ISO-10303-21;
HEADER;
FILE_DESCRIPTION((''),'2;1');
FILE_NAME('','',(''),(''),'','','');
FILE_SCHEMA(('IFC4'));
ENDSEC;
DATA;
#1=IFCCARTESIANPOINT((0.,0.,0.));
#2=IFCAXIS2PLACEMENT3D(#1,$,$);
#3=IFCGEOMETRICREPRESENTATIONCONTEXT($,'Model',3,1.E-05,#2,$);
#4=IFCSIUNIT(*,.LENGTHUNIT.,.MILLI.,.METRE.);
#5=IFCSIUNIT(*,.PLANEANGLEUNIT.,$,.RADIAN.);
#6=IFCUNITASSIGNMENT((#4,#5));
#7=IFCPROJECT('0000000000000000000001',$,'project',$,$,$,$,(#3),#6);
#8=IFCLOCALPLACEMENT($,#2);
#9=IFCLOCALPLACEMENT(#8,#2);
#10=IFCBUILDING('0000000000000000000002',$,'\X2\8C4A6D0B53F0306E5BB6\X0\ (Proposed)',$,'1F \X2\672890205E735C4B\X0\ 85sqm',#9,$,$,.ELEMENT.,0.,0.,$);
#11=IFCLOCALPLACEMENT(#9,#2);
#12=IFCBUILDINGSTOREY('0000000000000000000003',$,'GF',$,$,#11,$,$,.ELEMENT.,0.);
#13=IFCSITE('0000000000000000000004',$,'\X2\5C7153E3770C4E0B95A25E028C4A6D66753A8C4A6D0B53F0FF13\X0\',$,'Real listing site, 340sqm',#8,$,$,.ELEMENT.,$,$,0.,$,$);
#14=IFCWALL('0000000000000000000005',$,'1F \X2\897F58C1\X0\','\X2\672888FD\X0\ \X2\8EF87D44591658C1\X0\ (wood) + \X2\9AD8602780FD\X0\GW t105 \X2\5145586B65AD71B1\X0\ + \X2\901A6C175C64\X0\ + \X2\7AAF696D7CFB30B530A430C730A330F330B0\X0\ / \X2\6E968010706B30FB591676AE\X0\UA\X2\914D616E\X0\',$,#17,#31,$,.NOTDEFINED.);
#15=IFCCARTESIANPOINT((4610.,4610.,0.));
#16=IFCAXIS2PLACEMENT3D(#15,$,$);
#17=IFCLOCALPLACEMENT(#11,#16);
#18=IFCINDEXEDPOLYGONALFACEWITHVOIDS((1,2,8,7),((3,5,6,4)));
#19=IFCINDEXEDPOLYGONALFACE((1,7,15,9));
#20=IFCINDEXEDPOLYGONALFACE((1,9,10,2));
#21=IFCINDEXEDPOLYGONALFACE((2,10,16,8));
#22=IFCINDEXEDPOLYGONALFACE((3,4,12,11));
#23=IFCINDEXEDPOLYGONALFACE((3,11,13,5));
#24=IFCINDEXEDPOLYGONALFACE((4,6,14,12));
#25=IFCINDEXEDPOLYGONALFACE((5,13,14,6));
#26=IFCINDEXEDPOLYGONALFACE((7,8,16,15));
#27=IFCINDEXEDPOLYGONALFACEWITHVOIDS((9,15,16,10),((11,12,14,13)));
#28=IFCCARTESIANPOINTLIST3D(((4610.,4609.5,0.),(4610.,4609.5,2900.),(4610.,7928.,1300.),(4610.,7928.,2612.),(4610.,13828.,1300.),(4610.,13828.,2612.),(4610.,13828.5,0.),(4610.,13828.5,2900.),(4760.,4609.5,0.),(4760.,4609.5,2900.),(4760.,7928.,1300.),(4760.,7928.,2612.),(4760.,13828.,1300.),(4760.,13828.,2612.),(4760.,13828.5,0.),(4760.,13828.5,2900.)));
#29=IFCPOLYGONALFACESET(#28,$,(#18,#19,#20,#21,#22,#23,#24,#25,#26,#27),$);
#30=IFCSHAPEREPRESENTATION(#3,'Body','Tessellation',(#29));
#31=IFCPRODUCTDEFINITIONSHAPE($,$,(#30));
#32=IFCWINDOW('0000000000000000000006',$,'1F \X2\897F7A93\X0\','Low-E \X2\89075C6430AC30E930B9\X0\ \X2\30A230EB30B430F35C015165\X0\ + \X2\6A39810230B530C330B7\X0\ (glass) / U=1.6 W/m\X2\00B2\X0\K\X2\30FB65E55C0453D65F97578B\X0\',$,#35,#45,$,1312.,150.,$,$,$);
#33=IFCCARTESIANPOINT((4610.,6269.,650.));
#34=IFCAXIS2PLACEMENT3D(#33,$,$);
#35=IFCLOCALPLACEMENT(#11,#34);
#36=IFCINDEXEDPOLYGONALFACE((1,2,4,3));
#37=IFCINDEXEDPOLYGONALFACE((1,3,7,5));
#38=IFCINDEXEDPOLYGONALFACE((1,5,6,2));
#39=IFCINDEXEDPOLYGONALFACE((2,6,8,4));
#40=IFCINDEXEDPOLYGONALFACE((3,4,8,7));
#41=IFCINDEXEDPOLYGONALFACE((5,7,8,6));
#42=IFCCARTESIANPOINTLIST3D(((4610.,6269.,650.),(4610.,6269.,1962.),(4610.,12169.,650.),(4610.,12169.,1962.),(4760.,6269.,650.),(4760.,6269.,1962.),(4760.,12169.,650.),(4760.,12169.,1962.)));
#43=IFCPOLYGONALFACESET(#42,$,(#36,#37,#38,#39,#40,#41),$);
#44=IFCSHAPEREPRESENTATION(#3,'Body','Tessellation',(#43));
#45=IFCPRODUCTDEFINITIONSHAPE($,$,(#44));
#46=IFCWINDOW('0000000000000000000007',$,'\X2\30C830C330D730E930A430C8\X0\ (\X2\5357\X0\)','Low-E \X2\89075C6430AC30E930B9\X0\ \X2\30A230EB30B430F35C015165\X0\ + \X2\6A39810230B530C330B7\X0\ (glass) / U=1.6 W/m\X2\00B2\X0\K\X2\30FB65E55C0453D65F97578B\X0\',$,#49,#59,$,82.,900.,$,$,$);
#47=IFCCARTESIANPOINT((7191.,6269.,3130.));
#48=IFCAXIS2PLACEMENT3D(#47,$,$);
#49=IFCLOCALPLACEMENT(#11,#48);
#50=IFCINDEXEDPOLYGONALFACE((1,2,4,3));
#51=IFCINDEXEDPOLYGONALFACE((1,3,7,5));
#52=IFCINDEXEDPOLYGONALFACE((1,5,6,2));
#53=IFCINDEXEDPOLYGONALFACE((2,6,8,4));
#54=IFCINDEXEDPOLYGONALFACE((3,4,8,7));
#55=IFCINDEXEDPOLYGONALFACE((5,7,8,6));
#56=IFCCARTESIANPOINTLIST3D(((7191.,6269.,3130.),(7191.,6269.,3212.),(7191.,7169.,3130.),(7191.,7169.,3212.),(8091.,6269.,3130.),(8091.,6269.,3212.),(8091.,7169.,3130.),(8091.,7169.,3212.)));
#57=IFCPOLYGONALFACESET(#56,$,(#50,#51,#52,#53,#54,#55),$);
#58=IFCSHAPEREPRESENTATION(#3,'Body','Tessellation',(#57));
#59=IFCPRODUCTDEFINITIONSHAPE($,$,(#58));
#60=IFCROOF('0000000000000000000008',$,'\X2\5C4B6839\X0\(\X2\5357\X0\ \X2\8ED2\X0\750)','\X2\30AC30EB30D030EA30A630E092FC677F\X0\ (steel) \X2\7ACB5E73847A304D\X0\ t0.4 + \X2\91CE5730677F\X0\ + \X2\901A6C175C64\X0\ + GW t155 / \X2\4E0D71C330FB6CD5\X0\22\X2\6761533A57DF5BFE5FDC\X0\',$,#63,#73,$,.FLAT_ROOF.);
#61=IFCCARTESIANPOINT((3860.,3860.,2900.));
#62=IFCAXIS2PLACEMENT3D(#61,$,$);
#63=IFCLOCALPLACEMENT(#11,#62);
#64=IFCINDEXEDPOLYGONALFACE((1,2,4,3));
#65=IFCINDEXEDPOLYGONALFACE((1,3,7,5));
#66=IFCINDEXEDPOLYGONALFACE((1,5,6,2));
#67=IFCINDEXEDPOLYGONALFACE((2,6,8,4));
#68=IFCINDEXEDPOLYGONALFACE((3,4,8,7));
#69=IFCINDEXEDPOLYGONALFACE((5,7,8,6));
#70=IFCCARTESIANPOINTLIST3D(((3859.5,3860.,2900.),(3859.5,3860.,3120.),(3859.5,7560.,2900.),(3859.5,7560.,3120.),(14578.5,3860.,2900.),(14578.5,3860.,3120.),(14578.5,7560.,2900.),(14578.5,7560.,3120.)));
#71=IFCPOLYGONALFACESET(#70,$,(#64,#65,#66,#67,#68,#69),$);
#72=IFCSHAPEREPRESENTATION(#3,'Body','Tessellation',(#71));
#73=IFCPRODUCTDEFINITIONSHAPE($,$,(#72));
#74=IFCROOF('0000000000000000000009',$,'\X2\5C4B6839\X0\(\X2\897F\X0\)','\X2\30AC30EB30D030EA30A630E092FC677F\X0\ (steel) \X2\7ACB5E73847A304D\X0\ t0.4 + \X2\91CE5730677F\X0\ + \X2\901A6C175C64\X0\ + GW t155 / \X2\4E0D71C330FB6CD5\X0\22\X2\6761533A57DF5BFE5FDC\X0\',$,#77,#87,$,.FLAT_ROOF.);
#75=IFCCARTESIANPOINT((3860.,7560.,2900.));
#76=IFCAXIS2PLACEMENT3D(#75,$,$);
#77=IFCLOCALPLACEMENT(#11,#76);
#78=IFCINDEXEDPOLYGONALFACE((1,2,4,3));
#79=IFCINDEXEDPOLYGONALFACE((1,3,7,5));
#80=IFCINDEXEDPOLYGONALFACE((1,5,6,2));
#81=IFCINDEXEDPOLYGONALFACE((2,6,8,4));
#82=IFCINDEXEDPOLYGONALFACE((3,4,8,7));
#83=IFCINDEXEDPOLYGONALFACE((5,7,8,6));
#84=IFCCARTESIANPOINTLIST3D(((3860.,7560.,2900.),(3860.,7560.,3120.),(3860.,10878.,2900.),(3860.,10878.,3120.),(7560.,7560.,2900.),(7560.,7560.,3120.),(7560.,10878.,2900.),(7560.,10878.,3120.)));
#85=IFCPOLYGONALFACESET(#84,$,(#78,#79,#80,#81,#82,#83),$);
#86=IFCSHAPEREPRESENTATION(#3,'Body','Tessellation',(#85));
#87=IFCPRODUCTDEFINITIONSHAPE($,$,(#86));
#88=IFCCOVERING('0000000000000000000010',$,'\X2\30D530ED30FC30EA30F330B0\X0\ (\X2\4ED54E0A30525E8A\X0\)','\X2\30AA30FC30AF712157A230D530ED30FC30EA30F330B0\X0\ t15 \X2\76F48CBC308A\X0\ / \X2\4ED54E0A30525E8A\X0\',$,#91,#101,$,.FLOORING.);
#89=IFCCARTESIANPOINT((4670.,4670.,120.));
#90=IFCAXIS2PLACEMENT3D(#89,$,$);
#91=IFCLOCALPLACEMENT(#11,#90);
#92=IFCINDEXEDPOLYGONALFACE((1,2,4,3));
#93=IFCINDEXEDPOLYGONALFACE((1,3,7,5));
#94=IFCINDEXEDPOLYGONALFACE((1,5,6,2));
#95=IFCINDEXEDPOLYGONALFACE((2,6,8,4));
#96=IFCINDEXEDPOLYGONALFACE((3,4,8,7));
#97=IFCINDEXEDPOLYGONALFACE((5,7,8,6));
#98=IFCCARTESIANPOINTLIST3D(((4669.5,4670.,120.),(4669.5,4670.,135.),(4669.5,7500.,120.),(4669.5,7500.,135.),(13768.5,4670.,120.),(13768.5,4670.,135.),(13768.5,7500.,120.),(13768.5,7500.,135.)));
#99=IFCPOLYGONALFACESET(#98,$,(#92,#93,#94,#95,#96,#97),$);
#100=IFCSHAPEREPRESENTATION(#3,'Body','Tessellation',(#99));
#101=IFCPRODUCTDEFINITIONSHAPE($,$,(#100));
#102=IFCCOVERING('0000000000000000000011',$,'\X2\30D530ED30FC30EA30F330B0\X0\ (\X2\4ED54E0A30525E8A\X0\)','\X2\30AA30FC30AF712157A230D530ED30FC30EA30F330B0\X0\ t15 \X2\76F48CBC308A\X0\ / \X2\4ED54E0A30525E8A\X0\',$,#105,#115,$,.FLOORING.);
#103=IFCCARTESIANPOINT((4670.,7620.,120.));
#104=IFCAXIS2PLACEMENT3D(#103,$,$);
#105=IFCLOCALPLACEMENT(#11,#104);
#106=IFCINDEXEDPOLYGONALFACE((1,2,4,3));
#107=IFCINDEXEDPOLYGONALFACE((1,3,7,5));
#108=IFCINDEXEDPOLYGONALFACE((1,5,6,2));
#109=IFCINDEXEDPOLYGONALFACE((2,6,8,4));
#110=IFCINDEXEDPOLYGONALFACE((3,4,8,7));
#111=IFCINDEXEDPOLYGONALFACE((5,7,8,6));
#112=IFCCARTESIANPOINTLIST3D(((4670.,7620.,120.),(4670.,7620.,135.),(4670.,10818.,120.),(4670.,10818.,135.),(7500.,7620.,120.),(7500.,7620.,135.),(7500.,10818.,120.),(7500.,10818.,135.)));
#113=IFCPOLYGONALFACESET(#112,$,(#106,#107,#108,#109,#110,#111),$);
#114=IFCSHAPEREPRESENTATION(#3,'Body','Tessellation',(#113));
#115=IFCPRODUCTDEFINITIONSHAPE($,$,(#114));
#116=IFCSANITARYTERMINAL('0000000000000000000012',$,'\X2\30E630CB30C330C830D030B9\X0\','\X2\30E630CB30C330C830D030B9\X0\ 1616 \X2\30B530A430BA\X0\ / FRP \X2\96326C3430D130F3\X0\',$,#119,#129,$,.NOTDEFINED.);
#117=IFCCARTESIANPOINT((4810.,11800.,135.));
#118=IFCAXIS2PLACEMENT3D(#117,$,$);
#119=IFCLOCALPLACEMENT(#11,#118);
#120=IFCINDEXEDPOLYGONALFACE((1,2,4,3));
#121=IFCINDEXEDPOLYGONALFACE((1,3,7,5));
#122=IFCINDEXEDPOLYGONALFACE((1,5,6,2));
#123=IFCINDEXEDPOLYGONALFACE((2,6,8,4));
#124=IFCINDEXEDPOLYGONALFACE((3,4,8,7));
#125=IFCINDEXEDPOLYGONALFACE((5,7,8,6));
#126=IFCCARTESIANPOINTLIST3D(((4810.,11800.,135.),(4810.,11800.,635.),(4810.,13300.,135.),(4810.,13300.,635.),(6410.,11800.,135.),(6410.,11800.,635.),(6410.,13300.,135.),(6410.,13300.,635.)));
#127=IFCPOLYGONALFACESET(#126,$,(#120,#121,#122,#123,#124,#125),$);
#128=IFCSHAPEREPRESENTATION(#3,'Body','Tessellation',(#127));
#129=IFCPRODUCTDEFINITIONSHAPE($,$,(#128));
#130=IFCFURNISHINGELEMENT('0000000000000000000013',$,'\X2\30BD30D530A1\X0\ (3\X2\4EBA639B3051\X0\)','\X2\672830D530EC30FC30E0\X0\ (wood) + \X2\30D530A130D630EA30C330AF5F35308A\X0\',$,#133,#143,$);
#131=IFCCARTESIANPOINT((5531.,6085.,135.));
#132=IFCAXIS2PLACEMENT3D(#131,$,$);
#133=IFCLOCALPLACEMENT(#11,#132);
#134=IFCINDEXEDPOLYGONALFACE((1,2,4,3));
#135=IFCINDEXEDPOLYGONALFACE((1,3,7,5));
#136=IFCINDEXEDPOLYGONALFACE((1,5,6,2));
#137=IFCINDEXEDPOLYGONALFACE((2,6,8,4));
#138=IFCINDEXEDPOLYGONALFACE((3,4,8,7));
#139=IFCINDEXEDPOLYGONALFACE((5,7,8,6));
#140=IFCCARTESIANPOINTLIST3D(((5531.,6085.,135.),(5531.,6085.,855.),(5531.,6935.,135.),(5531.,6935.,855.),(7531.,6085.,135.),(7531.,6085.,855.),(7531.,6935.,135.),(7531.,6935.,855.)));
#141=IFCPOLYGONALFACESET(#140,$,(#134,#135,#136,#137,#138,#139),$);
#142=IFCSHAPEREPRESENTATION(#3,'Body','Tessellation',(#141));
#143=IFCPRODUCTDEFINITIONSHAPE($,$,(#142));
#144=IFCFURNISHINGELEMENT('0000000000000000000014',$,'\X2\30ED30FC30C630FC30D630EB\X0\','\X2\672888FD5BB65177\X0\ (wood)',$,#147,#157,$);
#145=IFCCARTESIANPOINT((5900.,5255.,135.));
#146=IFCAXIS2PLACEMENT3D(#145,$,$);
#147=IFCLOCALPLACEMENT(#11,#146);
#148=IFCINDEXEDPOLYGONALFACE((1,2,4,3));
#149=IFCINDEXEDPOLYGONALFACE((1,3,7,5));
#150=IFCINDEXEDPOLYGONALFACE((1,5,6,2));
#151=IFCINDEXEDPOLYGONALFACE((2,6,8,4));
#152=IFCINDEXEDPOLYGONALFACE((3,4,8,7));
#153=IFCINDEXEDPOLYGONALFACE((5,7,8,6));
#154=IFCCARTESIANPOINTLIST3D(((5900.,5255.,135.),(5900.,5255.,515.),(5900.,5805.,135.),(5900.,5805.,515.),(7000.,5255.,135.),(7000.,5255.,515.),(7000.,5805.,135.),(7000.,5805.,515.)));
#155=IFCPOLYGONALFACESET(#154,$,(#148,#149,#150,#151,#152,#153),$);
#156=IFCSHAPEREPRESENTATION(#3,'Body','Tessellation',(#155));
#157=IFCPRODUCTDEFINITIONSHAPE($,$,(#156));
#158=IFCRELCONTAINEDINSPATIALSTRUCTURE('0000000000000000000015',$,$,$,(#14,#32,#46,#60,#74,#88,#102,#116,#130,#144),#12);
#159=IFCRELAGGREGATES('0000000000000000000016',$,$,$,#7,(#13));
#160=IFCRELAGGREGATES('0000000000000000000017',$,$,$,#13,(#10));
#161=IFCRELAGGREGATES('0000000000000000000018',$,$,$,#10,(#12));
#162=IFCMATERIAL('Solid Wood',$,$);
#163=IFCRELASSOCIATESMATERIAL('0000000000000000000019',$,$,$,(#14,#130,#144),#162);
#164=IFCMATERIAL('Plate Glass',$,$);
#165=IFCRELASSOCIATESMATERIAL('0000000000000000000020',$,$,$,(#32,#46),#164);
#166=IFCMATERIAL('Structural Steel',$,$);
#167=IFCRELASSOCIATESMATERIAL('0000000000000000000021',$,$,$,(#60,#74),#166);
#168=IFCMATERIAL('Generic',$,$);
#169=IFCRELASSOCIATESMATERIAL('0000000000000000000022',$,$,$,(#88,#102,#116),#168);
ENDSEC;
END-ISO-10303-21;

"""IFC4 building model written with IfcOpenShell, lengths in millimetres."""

from ifc_helpers import new_model, si_unit, frame, frame_2d, origin, place, context, project, spatial, rectangle, extrude, material, element, fill, save


model = new_model("IFC4")

# Units and contexts
model_context = context("Model", 3, precision=1e-05, world=origin())
ifc_project = project(units=[si_unit("LENGTHUNIT", "METRE", prefix="MILLI"), si_unit("PLANEANGLEUNIT", "RADIAN")], contexts=[model_context])

# Site, building, storey
site_placement = place(None, origin())
site = spatial("IfcSite", under=ifc_project, at=site_placement, Name="山口県下関市豊浦町豊洋台３", ObjectType="Real listing site, 340sqm", CompositionType="ELEMENT", RefElevation=0.0)
building_placement = place(site_placement, origin())
building = spatial("IfcBuilding", under=site, at=building_placement, Name="豊洋台の家 (Proposed)", ObjectType="1F 木造平屋 85sqm", CompositionType="ELEMENT", ElevationOfRefHeight=0.0, ElevationOfTerrain=0.0)
storey_placement = place(building_placement, origin())
storey = spatial("IfcBuildingStorey", under=building, at=storey_placement, Name="GF", CompositionType="ELEMENT", Elevation=0.0)

# Shared definitions
ifc_material_1 = material(Name="Solid Wood")

# Shared definitions
ifc_material_2 = material(Name="Plate Glass")

# Wall, opening, window
wall_1_placement = place(storey_placement, frame((4610.0, 4610.0, 0.0)))
wall_1 = element("IfcWall", 1, at=wall_1_placement, inside=storey, material=ifc_material_1, Name="1F 西壁", Description="木製 軸組外壁 (wood) + 高性能GW t105 充填断熱 + 通気層 + 窯業系サイディング / 準耐火・外皮UA配慮", PredefinedType="NOTDEFINED", context=model_context, shape_type="SweptSolid", body=[
    extrude(rectangle(XDim=150.0, YDim=9219.0, at=frame_2d((75.0, 4609.0))), frame((4610.0, 4610.0, 0.0)), (0.0, 0.0, 1.0), 2900.0),
])
opening_1_placement = place(storey_placement, frame((4610.0, 6269.0, 650.0)))
opening_1 = element("IfcOpeningElement", 2, at=opening_1_placement, cuts=wall_1, PredefinedType="NOTDEFINED", context=model_context, shape_type="SweptSolid", body=[
    extrude(rectangle(XDim=150.0, YDim=5900.0, at=frame_2d((75.0, 2950.0))), frame((4610.0, 6269.0, 650.0)), (0.0, 0.0, 1.0), 1312.0),
])
window_1_placement = place(storey_placement, frame((4610.0, 6269.0, 650.0)))
window_1 = element("IfcWindow", 3, at=window_1_placement, inside=storey, material=ifc_material_2, Name="1F 西窓", Description="Low-E 複層ガラス アルゴン封入 + 樹脂サッシ (glass) / U=1.6 W/m²K・日射取得型", OverallHeight=1312.0, OverallWidth=150.0, context=model_context, shape_type="SweptSolid", body=[
    extrude(rectangle(XDim=150.0, YDim=5900.0, at=frame_2d((75.0, 2950.0))), frame((4610.0, 6269.0, 650.0)), (0.0, 0.0, 1.0), 1312.0),
])
fill(opening_1, window_1)

# Window
window_2_placement = place(storey_placement, frame((7191.0, 6269.0, 3130.0)))
element("IfcWindow", 4, at=window_2_placement, inside=storey, material=ifc_material_2, Name="トップライト (南)", Description="Low-E 複層ガラス アルゴン封入 + 樹脂サッシ (glass) / U=1.6 W/m²K・日射取得型", OverallHeight=82.0, OverallWidth=900.0, context=model_context, shape_type="SweptSolid", body=[
    extrude(rectangle(XDim=900.0, YDim=900.0, at=frame_2d((450.0, 450.0))), frame((7191.0, 6269.0, 3130.0)), (0.0, 0.0, 1.0), 82.0),
])

# Roofs
ifc_material_3 = material(Name="Structural Steel")
roof_1_placement = place(storey_placement, frame((3860.0, 3860.0, 2900.0)))
element("IfcRoof", 5, at=roof_1_placement, inside=storey, material=ifc_material_3, Name="屋根(南 軒750)", Description="ガルバリウム鋼板 (steel) 立平葺き t0.4 + 野地板 + 通気層 + GW t155 / 不燃・法22条区域対応", PredefinedType="FLAT_ROOF", context=model_context, shape_type="SweptSolid", body=[
    extrude(rectangle(XDim=10719.0, YDim=3700.0, at=frame_2d((5359.0, 1850.0))), frame((3860.0, 3860.0, 2900.0)), (0.0, 0.0, 1.0), 220.0),
])
roof_2_placement = place(storey_placement, frame((3860.0, 7560.0, 2900.0)))
element("IfcRoof", 6, at=roof_2_placement, inside=storey, material=ifc_material_3, Name="屋根(西)", Description="ガルバリウム鋼板 (steel) 立平葺き t0.4 + 野地板 + 通気層 + GW t155 / 不燃・法22条区域対応", PredefinedType="FLAT_ROOF", context=model_context, shape_type="SweptSolid", body=[
    extrude(rectangle(XDim=3700.0, YDim=3318.0, at=frame_2d((1850.0, 1659.0))), frame((3860.0, 7560.0, 2900.0)), (0.0, 0.0, 1.0), 220.0),
])

# Coverings
ifc_material_4 = material(Name="Generic")
covering_1_placement = place(storey_placement, frame((4670.0, 4670.0, 120.0)))
element("IfcCovering", 7, at=covering_1_placement, inside=storey, material=ifc_material_4, Name="フローリング (仕上げ床)", Description="オーク無垢フローリング t15 直貼り / 仕上げ床", PredefinedType="FLOORING", context=model_context, shape_type="SweptSolid", body=[
    extrude(rectangle(XDim=9099.0, YDim=2830.0, at=frame_2d((4549.0, 1415.0))), frame((4670.0, 4670.0, 120.0)), (0.0, 0.0, 1.0), 15.0),
])
covering_2_placement = place(storey_placement, frame((4670.0, 7620.0, 120.0)))
element("IfcCovering", 8, at=covering_2_placement, inside=storey, material=ifc_material_4, Name="フローリング (仕上げ床)", Description="オーク無垢フローリング t15 直貼り / 仕上げ床", PredefinedType="FLOORING", context=model_context, shape_type="SweptSolid", body=[
    extrude(rectangle(XDim=2830.0, YDim=3198.0, at=frame_2d((1415.0, 1599.0))), frame((4670.0, 7620.0, 120.0)), (0.0, 0.0, 1.0), 15.0),
])

# Sanitary terminal
sanitary_terminal_placement = place(storey_placement, frame((4810.0, 11800.0, 135.0)))
element("IfcSanitaryTerminal", 9, at=sanitary_terminal_placement, inside=storey, material=ifc_material_4, Name="ユニットバス", Description="ユニットバス 1616 サイズ / FRP 防水パン", PredefinedType="NOTDEFINED", context=model_context, shape_type="SweptSolid", body=[
    extrude(rectangle(XDim=1600.0, YDim=1500.0, at=frame_2d((800.0, 750.0))), frame((4810.0, 11800.0, 135.0)), (0.0, 0.0, 1.0), 500.0),
])

# Furnishing elements
furnishing_1_placement = place(storey_placement, frame((5531.0, 6085.0, 135.0)))
element("IfcFurnishingElement", 10, at=furnishing_1_placement, inside=storey, material=ifc_material_1, Name="ソファ (3人掛け)", Description="木フレーム (wood) + ファブリック張り", context=model_context, shape_type="SweptSolid", body=[
    extrude(rectangle(XDim=2000.0, YDim=850.0, at=frame_2d((1000.0, 425.0))), frame((5531.0, 6085.0, 135.0)), (0.0, 0.0, 1.0), 720.0),
])
furnishing_2_placement = place(storey_placement, frame((5900.0, 5255.0, 135.0)))
element("IfcFurnishingElement", 11, at=furnishing_2_placement, inside=storey, material=ifc_material_1, Name="ローテーブル", Description="木製家具 (wood)", context=model_context, shape_type="SweptSolid", body=[
    extrude(rectangle(XDim=1100.0, YDim=550.0, at=frame_2d((550.0, 275.0))), frame((5900.0, 5255.0, 135.0)), (0.0, 0.0, 1.0), 380.0),
])

save(model, "model.ifc")
